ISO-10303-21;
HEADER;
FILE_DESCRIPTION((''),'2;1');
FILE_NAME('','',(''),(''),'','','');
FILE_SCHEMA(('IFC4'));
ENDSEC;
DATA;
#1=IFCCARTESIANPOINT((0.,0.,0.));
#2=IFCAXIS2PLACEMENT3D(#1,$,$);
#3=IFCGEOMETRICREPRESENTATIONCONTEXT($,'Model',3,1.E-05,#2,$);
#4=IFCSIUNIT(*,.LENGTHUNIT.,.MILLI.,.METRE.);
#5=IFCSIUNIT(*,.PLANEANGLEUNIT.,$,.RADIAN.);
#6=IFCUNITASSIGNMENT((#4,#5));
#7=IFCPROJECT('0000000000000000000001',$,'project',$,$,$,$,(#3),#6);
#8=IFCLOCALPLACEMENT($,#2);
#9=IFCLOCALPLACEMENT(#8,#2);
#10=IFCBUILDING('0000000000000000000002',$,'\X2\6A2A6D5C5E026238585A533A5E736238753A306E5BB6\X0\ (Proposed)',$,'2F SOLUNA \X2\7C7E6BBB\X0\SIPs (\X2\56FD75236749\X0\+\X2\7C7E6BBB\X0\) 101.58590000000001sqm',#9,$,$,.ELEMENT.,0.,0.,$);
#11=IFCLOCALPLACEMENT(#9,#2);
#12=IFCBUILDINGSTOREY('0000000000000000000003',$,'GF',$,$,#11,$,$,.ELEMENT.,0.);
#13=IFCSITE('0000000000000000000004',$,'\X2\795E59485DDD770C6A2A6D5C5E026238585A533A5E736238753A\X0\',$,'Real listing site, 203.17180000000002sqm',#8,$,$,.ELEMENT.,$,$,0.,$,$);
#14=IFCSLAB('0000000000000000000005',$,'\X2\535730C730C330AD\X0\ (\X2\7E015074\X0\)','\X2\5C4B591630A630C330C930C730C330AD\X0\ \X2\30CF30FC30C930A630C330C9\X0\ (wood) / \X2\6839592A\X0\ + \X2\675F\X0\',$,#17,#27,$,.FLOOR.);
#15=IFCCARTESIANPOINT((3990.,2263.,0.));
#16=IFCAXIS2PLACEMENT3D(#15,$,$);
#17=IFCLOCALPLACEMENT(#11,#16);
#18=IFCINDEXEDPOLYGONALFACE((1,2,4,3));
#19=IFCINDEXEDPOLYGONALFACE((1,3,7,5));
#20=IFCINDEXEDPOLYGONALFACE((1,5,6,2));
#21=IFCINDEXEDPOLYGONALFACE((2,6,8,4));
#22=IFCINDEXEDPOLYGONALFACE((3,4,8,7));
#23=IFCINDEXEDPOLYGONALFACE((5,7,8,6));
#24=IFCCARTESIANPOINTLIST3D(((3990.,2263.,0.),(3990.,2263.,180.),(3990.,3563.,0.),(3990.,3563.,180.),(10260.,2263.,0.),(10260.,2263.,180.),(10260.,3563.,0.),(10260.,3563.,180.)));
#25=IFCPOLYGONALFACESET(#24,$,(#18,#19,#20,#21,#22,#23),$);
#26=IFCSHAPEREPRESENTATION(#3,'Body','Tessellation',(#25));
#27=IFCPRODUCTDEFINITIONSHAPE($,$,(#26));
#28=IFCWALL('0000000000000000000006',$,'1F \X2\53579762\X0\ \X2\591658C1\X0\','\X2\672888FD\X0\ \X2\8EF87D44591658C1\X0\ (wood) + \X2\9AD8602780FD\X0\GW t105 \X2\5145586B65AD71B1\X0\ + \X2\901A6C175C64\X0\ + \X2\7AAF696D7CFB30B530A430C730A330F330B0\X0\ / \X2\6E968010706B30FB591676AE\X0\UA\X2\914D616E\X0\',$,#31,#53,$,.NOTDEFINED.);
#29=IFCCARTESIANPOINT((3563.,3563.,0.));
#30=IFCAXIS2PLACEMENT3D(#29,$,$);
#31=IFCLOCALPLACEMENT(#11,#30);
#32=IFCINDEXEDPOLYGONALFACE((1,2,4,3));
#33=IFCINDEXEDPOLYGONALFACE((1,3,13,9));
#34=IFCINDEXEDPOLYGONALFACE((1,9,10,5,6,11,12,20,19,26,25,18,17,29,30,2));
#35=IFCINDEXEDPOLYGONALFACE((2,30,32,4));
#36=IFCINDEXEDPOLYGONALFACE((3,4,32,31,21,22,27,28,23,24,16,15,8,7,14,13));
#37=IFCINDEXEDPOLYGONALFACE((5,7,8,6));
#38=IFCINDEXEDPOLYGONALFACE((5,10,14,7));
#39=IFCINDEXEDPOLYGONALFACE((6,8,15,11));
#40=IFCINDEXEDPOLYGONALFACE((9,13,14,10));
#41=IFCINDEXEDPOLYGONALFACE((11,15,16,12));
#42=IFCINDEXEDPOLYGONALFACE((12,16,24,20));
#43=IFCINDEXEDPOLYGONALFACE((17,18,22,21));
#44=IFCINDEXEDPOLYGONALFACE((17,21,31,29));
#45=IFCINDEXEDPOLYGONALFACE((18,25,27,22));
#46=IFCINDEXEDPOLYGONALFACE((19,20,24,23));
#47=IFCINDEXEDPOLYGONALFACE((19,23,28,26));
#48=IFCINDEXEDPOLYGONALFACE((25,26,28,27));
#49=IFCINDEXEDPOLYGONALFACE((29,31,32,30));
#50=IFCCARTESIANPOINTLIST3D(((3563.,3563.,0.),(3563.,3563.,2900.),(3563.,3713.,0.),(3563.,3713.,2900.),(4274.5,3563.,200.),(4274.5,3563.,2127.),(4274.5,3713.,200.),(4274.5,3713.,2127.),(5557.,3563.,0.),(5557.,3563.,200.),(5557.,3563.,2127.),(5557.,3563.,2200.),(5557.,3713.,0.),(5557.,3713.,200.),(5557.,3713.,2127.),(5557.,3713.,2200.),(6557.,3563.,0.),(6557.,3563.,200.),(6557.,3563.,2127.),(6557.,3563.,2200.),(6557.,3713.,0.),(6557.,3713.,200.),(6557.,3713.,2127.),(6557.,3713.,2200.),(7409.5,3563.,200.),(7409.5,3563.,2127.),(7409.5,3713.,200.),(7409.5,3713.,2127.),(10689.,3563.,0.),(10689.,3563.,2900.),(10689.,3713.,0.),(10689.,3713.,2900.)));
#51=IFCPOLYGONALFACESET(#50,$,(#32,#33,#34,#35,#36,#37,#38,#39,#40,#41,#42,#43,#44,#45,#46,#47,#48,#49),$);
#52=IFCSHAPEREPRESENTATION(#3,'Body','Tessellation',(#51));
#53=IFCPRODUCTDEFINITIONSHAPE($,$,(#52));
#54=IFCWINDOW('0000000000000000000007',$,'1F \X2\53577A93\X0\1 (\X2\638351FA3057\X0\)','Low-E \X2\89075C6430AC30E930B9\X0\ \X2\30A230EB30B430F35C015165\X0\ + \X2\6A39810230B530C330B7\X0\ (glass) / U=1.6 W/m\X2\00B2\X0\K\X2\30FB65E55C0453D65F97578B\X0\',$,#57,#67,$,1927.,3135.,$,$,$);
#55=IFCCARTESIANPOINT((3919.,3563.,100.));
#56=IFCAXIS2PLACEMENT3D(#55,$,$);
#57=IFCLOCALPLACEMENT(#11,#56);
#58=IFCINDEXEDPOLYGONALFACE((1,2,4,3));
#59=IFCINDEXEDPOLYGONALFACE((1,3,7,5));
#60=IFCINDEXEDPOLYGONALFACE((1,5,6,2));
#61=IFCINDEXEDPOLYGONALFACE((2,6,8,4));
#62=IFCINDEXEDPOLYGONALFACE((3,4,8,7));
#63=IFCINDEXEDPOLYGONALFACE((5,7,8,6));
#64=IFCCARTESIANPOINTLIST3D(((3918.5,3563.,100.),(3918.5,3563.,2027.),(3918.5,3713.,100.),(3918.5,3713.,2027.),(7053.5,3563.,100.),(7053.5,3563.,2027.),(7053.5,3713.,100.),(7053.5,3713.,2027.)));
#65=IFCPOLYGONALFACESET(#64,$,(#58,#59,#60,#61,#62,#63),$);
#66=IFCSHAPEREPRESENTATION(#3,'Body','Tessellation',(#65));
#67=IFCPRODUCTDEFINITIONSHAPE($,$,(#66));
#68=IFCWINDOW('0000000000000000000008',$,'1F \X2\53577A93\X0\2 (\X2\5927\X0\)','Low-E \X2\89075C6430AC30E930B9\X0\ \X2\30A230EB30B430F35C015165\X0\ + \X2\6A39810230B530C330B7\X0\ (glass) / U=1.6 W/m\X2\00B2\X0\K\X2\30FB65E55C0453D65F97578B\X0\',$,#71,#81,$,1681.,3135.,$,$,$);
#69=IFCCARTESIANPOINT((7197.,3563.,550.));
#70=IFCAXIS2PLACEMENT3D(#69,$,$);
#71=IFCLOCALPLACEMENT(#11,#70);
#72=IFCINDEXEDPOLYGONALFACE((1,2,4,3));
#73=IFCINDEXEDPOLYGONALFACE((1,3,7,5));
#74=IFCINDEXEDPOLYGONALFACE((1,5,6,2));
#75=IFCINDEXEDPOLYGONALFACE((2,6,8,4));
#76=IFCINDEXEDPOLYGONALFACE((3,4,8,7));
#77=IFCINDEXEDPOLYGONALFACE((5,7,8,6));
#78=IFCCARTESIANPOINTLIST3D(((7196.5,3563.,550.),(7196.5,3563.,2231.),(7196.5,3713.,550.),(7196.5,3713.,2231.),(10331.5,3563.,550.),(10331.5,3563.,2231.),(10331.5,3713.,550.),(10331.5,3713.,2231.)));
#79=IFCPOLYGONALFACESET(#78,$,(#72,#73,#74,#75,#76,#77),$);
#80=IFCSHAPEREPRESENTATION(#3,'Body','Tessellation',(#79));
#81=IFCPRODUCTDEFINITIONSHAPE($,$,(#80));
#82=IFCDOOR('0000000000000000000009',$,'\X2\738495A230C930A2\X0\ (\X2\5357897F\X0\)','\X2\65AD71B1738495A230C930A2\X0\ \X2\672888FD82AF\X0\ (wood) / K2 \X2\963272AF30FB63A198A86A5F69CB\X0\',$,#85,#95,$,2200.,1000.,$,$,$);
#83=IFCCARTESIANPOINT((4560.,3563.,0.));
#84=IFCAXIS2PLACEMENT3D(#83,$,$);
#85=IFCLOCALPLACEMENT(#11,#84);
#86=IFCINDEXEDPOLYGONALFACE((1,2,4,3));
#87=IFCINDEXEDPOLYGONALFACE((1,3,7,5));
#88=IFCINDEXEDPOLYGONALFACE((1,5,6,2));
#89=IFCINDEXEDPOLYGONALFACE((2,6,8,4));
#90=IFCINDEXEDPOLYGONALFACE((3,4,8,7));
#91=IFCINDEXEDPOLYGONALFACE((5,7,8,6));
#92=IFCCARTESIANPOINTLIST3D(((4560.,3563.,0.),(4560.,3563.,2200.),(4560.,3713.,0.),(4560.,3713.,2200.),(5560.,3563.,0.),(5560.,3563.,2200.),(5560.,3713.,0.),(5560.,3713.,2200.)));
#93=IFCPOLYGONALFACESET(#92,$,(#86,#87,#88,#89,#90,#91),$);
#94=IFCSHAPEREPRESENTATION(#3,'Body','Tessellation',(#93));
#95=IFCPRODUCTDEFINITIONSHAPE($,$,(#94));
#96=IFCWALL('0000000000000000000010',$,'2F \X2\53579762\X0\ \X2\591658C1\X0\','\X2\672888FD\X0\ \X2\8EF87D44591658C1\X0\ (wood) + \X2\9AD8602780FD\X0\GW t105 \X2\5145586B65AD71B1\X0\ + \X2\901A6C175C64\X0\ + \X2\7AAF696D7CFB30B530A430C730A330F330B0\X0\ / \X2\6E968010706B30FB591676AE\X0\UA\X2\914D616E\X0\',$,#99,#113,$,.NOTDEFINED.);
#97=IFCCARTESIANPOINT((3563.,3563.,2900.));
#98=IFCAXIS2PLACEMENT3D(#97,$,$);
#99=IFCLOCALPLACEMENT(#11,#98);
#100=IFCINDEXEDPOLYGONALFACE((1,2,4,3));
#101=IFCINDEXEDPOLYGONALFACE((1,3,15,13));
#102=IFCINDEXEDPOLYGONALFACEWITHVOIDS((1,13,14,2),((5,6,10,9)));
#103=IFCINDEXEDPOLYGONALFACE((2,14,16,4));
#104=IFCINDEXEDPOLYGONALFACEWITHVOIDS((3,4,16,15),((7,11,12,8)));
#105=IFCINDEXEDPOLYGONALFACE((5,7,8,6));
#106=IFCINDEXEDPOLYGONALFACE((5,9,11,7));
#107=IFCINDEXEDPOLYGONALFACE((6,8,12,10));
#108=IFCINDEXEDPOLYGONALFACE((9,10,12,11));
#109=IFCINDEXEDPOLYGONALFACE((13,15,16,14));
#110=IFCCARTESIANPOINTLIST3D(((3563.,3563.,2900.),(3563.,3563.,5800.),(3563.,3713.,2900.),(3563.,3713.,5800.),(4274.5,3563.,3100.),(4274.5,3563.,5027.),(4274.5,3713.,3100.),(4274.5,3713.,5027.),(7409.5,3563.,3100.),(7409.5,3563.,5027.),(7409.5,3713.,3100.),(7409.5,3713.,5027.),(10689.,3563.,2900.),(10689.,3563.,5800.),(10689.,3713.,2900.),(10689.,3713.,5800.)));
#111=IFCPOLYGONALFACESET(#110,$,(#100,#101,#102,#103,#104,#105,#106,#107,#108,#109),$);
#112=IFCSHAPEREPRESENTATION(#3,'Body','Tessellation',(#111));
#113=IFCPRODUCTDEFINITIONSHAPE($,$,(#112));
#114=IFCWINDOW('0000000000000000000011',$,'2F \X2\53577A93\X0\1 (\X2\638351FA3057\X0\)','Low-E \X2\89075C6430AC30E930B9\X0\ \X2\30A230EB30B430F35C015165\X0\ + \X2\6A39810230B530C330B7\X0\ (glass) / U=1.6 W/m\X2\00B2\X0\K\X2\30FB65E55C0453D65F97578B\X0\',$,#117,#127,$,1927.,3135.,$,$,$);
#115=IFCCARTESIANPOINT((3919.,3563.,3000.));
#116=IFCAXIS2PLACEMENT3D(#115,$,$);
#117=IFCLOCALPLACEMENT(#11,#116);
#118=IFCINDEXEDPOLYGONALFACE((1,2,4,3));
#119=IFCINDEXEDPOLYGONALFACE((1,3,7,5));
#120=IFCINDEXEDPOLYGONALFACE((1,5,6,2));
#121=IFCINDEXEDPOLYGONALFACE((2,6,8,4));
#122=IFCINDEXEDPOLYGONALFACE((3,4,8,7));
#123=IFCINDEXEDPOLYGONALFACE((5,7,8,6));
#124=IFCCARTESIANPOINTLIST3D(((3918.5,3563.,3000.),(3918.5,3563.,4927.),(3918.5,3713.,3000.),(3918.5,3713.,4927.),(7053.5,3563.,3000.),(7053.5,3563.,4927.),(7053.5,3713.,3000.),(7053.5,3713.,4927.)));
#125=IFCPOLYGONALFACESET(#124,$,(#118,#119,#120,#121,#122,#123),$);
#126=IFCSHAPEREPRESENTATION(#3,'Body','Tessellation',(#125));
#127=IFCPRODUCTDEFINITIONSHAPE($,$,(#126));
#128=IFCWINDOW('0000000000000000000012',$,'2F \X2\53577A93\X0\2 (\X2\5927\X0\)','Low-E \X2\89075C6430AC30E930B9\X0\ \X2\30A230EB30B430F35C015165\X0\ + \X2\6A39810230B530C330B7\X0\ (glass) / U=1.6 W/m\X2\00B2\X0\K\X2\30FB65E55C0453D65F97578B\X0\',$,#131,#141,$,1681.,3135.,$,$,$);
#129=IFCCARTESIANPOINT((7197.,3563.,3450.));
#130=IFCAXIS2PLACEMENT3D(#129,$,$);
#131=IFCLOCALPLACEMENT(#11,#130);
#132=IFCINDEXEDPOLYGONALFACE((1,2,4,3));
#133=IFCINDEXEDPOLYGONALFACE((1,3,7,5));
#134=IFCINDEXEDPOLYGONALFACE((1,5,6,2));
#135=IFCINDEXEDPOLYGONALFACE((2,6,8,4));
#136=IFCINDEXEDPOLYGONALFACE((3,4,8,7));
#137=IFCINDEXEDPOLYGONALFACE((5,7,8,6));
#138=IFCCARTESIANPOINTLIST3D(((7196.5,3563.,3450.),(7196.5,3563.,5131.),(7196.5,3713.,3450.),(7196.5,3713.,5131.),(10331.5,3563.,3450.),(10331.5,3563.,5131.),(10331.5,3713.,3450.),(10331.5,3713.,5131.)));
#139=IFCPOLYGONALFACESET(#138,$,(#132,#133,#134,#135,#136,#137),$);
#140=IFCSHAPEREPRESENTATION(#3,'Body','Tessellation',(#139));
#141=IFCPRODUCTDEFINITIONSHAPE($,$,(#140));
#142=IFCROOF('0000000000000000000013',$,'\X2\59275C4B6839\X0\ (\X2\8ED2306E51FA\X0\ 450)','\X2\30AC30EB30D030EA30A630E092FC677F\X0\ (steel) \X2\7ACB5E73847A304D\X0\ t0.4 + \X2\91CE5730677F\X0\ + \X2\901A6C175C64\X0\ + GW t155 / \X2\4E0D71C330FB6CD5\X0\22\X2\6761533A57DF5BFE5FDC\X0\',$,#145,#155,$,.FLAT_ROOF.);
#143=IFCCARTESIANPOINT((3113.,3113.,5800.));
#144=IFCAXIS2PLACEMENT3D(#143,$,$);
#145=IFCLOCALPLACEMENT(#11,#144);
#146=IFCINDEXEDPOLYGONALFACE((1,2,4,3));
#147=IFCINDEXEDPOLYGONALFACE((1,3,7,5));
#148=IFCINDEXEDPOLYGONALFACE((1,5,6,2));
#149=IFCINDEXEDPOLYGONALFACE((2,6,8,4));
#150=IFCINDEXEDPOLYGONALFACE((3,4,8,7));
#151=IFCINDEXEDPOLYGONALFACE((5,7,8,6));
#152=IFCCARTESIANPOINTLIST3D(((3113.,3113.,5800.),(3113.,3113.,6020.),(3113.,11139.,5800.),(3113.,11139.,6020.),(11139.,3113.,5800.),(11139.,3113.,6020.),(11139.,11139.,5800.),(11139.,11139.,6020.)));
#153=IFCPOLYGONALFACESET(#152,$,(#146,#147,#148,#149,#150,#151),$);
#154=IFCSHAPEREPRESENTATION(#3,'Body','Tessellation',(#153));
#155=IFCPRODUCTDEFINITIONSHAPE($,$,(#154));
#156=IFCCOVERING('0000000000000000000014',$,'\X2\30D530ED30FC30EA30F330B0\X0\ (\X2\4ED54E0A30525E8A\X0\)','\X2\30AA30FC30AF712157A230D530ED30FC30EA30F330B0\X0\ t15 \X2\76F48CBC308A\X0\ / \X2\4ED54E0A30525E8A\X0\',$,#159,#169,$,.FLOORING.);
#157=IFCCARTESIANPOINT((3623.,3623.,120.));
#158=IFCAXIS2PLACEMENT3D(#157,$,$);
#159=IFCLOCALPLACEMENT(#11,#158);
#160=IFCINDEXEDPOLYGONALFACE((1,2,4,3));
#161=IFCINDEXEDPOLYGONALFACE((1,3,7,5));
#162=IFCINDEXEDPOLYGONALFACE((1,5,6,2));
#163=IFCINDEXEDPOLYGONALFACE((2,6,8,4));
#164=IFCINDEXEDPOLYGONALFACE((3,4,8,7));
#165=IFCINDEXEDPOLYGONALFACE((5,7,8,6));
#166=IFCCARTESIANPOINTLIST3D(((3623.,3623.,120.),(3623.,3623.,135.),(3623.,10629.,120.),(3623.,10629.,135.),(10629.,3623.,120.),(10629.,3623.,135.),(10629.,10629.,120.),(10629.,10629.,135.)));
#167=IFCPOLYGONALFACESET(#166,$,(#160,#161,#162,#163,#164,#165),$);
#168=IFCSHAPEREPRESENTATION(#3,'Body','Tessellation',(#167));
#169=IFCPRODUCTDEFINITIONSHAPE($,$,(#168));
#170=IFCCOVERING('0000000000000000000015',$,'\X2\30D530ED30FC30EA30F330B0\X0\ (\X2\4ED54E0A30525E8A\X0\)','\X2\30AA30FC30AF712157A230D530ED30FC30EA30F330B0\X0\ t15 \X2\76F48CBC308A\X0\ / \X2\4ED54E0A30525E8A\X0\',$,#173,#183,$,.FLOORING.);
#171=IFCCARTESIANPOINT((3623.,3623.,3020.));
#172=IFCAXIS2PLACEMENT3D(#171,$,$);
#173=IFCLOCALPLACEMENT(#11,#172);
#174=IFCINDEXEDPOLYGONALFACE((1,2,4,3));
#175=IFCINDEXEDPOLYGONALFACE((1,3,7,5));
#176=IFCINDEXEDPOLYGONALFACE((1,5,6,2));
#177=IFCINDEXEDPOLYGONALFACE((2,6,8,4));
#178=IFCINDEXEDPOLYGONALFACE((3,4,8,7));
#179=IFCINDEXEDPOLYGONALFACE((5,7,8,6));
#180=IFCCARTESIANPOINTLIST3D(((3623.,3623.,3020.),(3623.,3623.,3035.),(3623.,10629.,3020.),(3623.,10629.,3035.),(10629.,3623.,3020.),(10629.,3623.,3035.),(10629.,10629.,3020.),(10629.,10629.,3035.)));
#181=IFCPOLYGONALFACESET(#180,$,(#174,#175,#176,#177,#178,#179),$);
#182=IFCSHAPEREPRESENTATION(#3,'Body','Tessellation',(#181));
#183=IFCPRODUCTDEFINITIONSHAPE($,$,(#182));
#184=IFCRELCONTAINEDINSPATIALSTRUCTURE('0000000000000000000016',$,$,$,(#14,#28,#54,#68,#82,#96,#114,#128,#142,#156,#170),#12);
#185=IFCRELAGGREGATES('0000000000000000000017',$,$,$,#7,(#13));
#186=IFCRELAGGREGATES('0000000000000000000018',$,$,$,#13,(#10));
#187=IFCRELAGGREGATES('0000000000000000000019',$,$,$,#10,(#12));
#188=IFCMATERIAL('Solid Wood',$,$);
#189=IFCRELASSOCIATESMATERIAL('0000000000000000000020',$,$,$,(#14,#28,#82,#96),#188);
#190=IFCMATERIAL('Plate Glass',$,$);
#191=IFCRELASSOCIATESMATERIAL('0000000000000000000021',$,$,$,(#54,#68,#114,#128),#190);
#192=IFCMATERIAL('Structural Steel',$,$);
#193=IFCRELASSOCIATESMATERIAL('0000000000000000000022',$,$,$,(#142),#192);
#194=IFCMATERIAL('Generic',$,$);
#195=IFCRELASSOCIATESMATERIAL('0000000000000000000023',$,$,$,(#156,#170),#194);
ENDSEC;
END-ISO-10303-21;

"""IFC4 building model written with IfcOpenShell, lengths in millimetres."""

from ifc_helpers import new_model, si_unit, frame, frame_2d, origin, place, context, project, spatial, rectangle, extrude, material, element, fill, save


model = new_model("IFC4")

# Units and contexts
model_context = context("Model", 3, precision=1e-05, world=origin())
ifc_project = project(units=[si_unit("LENGTHUNIT", "METRE", prefix="MILLI"), si_unit("PLANEANGLEUNIT", "RADIAN")], contexts=[model_context])

# Site, building, storey
site_placement = place(None, origin())
site = spatial("IfcSite", under=ifc_project, at=site_placement, Name="神奈川県横浜市戸塚区平戸町", ObjectType="Real listing site, 203.17180000000002sqm", CompositionType="ELEMENT", RefElevation=0.0)
building_placement = place(site_placement, origin())
building = spatial("IfcBuilding", under=site, at=building_placement, Name="横浜市戸塚区平戸町の家 (Proposed)", ObjectType="2F SOLUNA 籾殻SIPs (国産杉+籾殻) 101.58590000000001sqm", CompositionType="ELEMENT", ElevationOfRefHeight=0.0, ElevationOfTerrain=0.0)
storey_placement = place(building_placement, origin())
storey = spatial("IfcBuildingStorey", under=building, at=storey_placement, Name="GF", CompositionType="ELEMENT", Elevation=0.0)

# Slab
ifc_material_1 = material(Name="Solid Wood")
slab_1_placement = place(storey_placement, frame((3990.0, 2263.0, 0.0)))
element("IfcSlab", 1, at=slab_1_placement, inside=storey, material=ifc_material_1, Name="南デッキ (縁側)", Description="屋外ウッドデッキ ハードウッド (wood) / 根太 + 束", PredefinedType="FLOOR", context=model_context, shape_type="SweptSolid", body=[
    extrude(rectangle(XDim=6270.0, YDim=1300.0, at=frame_2d((3135.0, 650.0))), frame((3990.0, 2263.0, 0.0)), (0.0, 0.0, 1.0), 180.0),
])

# Wall, openings, windows, door
wall_1_placement = place(storey_placement, frame((3563.0, 3563.0, 0.0)))
wall_1 = element("IfcWall", 2, at=wall_1_placement, inside=storey, material=ifc_material_1, Name="1F 南面 外壁", Description="木製 軸組外壁 (wood) + 高性能GW t105 充填断熱 + 通気層 + 窯業系サイディング / 準耐火・外皮UA配慮", PredefinedType="NOTDEFINED", context=model_context, shape_type="SweptSolid", body=[
    extrude(rectangle(XDim=7126.0, YDim=150.0, at=frame_2d((3563.0, 75.0))), frame((3563.0, 3563.0, 0.0)), (0.0, 0.0, 1.0), 2900.0),
])
opening_1_placement = place(storey_placement, frame((3919.0, 3563.0, 100.0)))
opening_1 = element("IfcOpeningElement", 3, at=opening_1_placement, cuts=wall_1, PredefinedType="NOTDEFINED", context=model_context, shape_type="SweptSolid", body=[
    extrude(rectangle(XDim=3135.0, YDim=150.0, at=frame_2d((1567.0, 75.0))), frame((3919.0, 3563.0, 100.0)), (0.0, 0.0, 1.0), 1927.0),
])
opening_2_placement = place(storey_placement, frame((7197.0, 3563.0, 550.0)))
opening_2 = element("IfcOpeningElement", 4, at=opening_2_placement, cuts=wall_1, PredefinedType="NOTDEFINED", context=model_context, shape_type="SweptSolid", body=[
    extrude(rectangle(XDim=3135.0, YDim=150.0, at=frame_2d((1567.0, 75.0))), frame((7197.0, 3563.0, 550.0)), (0.0, 0.0, 1.0), 1681.0),
])
opening_3_placement = place(storey_placement, frame((4560.0, 3563.0, 0.0)))
opening_3 = element("IfcOpeningElement", 5, at=opening_3_placement, cuts=wall_1, PredefinedType="NOTDEFINED", context=model_context, shape_type="SweptSolid", body=[
    extrude(rectangle(XDim=1000.0, YDim=150.0, at=frame_2d((500.0, 75.0))), frame((4560.0, 3563.0, 0.0)), (0.0, 0.0, 1.0), 2200.0),
])
ifc_material_2 = material(Name="Plate Glass")
window_1_placement = place(storey_placement, frame((3919.0, 3563.0, 100.0)))
window_1 = element("IfcWindow", 6, at=window_1_placement, inside=storey, material=ifc_material_2, Name="1F 南窓1 (掃出し)", Description="Low-E 複層ガラス アルゴン封入 + 樹脂サッシ (glass) / U=1.6 W/m²K・日射取得型", OverallHeight=1927.0, OverallWidth=3135.0, context=model_context, shape_type="SweptSolid", body=[
    extrude(rectangle(XDim=3135.0, YDim=150.0, at=frame_2d((1567.0, 75.0))), frame((3919.0, 3563.0, 100.0)), (0.0, 0.0, 1.0), 1927.0),
])
fill(opening_1, window_1)
window_2_placement = place(storey_placement, frame((7197.0, 3563.0, 550.0)))
window_2 = element("IfcWindow", 7, at=window_2_placement, inside=storey, material=ifc_material_2, Name="1F 南窓2 (大)", Description="Low-E 複層ガラス アルゴン封入 + 樹脂サッシ (glass) / U=1.6 W/m²K・日射取得型", OverallHeight=1681.0, OverallWidth=3135.0, context=model_context, shape_type="SweptSolid", body=[
    extrude(rectangle(XDim=3135.0, YDim=150.0, at=frame_2d((1567.0, 75.0))), frame((7197.0, 3563.0, 550.0)), (0.0, 0.0, 1.0), 1681.0),
])
fill(opening_2, window_2)
door_placement = place(storey_placement, frame((4560.0, 3563.0, 0.0)))
door = element("IfcDoor", 8, at=door_placement, inside=storey, material=ifc_material_1, Name="玄関ドア (南西)", Description="断熱玄関ドア 木製芯 (wood) / K2 防犯・採風機構", OverallHeight=2200.0, OverallWidth=1000.0, context=model_context, shape_type="SweptSolid", body=[
    extrude(rectangle(XDim=1000.0, YDim=150.0, at=frame_2d((500.0, 75.0))), frame((4560.0, 3563.0, 0.0)), (0.0, 0.0, 1.0), 2200.0),
])
fill(opening_3, door)

# Wall, openings, windows
wall_2_placement = place(storey_placement, frame((3563.0, 3563.0, 2900.0)))
wall_2 = element("IfcWall", 9, at=wall_2_placement, inside=storey, material=ifc_material_1, Name="2F 南面 外壁", Description="木製 軸組外壁 (wood) + 高性能GW t105 充填断熱 + 通気層 + 窯業系サイディング / 準耐火・外皮UA配慮", PredefinedType="NOTDEFINED", context=model_context, shape_type="SweptSolid", body=[
    extrude(rectangle(XDim=7126.0, YDim=150.0, at=frame_2d((3563.0, 75.0))), frame((3563.0, 3563.0, 2900.0)), (0.0, 0.0, 1.0), 2900.0),
])
opening_4_placement = place(storey_placement, frame((3919.0, 3563.0, 3000.0)))
opening_4 = element("IfcOpeningElement", 10, at=opening_4_placement, cuts=wall_2, PredefinedType="NOTDEFINED", context=model_context, shape_type="SweptSolid", body=[
    extrude(rectangle(XDim=3135.0, YDim=150.0, at=frame_2d((1567.0, 75.0))), frame((3919.0, 3563.0, 3000.0)), (0.0, 0.0, 1.0), 1927.0),
])
opening_5_placement = place(storey_placement, frame((7197.0, 3563.0, 3450.0)))
opening_5 = element("IfcOpeningElement", 11, at=opening_5_placement, cuts=wall_2, PredefinedType="NOTDEFINED", context=model_context, shape_type="SweptSolid", body=[
    extrude(rectangle(XDim=3135.0, YDim=150.0, at=frame_2d((1567.0, 75.0))), frame((7197.0, 3563.0, 3450.0)), (0.0, 0.0, 1.0), 1681.0),
])
window_3_placement = place(storey_placement, frame((3919.0, 3563.0, 3000.0)))
window_3 = element("IfcWindow", 12, at=window_3_placement, inside=storey, material=ifc_material_2, Name="2F 南窓1 (掃出し)", Description="Low-E 複層ガラス アルゴン封入 + 樹脂サッシ (glass) / U=1.6 W/m²K・日射取得型", OverallHeight=1927.0, OverallWidth=3135.0, context=model_context, shape_type="SweptSolid", body=[
    extrude(rectangle(XDim=3135.0, YDim=150.0, at=frame_2d((1567.0, 75.0))), frame((3919.0, 3563.0, 3000.0)), (0.0, 0.0, 1.0), 1927.0),
])
fill(opening_4, window_3)
window_4_placement = place(storey_placement, frame((7197.0, 3563.0, 3450.0)))
window_4 = element("IfcWindow", 13, at=window_4_placement, inside=storey, material=ifc_material_2, Name="2F 南窓2 (大)", Description="Low-E 複層ガラス アルゴン封入 + 樹脂サッシ (glass) / U=1.6 W/m²K・日射取得型", OverallHeight=1681.0, OverallWidth=3135.0, context=model_context, shape_type="SweptSolid", body=[
    extrude(rectangle(XDim=3135.0, YDim=150.0, at=frame_2d((1567.0, 75.0))), frame((7197.0, 3563.0, 3450.0)), (0.0, 0.0, 1.0), 1681.0),
])
fill(opening_5, window_4)

# Roof
ifc_material_3 = material(Name="Structural Steel")
roof_placement = place(storey_placement, frame((3113.0, 3113.0, 5800.0)))
element("IfcRoof", 14, at=roof_placement, inside=storey, material=ifc_material_3, Name="大屋根 (軒の出 450)", Description="ガルバリウム鋼板 (steel) 立平葺き t0.4 + 野地板 + 通気層 + GW t155 / 不燃・法22条区域対応", PredefinedType="FLAT_ROOF", context=model_context, shape_type="SweptSolid", body=[
    extrude(rectangle(XDim=8026.0, YDim=8026.0, at=frame_2d((4013.0, 4013.0))), frame((3113.0, 3113.0, 5800.0)), (0.0, 0.0, 1.0), 220.0),
])

# Coverings
ifc_material_4 = material(Name="Generic")
covering_1_placement = place(storey_placement, frame((3623.0, 3623.0, 120.0)))
element("IfcCovering", 15, at=covering_1_placement, inside=storey, material=ifc_material_4, Name="フローリング (仕上げ床)", Description="オーク無垢フローリング t15 直貼り / 仕上げ床", PredefinedType="FLOORING", context=model_context, shape_type="SweptSolid", body=[
    extrude(rectangle(XDim=7006.0, YDim=7006.0, at=frame_2d((3503.0, 3503.0))), frame((3623.0, 3623.0, 120.0)), (0.0, 0.0, 1.0), 15.0),
])
covering_2_placement = place(storey_placement, frame((3623.0, 3623.0, 3020.0)))
element("IfcCovering", 16, at=covering_2_placement, inside=storey, material=ifc_material_4, Name="フローリング (仕上げ床)", Description="オーク無垢フローリング t15 直貼り / 仕上げ床", PredefinedType="FLOORING", context=model_context, shape_type="SweptSolid", body=[
    extrude(rectangle(XDim=7006.0, YDim=7006.0, at=frame_2d((3503.0, 3503.0))), frame((3623.0, 3623.0, 3020.0)), (0.0, 0.0, 1.0), 15.0),
])

save(model, "model.ifc")
